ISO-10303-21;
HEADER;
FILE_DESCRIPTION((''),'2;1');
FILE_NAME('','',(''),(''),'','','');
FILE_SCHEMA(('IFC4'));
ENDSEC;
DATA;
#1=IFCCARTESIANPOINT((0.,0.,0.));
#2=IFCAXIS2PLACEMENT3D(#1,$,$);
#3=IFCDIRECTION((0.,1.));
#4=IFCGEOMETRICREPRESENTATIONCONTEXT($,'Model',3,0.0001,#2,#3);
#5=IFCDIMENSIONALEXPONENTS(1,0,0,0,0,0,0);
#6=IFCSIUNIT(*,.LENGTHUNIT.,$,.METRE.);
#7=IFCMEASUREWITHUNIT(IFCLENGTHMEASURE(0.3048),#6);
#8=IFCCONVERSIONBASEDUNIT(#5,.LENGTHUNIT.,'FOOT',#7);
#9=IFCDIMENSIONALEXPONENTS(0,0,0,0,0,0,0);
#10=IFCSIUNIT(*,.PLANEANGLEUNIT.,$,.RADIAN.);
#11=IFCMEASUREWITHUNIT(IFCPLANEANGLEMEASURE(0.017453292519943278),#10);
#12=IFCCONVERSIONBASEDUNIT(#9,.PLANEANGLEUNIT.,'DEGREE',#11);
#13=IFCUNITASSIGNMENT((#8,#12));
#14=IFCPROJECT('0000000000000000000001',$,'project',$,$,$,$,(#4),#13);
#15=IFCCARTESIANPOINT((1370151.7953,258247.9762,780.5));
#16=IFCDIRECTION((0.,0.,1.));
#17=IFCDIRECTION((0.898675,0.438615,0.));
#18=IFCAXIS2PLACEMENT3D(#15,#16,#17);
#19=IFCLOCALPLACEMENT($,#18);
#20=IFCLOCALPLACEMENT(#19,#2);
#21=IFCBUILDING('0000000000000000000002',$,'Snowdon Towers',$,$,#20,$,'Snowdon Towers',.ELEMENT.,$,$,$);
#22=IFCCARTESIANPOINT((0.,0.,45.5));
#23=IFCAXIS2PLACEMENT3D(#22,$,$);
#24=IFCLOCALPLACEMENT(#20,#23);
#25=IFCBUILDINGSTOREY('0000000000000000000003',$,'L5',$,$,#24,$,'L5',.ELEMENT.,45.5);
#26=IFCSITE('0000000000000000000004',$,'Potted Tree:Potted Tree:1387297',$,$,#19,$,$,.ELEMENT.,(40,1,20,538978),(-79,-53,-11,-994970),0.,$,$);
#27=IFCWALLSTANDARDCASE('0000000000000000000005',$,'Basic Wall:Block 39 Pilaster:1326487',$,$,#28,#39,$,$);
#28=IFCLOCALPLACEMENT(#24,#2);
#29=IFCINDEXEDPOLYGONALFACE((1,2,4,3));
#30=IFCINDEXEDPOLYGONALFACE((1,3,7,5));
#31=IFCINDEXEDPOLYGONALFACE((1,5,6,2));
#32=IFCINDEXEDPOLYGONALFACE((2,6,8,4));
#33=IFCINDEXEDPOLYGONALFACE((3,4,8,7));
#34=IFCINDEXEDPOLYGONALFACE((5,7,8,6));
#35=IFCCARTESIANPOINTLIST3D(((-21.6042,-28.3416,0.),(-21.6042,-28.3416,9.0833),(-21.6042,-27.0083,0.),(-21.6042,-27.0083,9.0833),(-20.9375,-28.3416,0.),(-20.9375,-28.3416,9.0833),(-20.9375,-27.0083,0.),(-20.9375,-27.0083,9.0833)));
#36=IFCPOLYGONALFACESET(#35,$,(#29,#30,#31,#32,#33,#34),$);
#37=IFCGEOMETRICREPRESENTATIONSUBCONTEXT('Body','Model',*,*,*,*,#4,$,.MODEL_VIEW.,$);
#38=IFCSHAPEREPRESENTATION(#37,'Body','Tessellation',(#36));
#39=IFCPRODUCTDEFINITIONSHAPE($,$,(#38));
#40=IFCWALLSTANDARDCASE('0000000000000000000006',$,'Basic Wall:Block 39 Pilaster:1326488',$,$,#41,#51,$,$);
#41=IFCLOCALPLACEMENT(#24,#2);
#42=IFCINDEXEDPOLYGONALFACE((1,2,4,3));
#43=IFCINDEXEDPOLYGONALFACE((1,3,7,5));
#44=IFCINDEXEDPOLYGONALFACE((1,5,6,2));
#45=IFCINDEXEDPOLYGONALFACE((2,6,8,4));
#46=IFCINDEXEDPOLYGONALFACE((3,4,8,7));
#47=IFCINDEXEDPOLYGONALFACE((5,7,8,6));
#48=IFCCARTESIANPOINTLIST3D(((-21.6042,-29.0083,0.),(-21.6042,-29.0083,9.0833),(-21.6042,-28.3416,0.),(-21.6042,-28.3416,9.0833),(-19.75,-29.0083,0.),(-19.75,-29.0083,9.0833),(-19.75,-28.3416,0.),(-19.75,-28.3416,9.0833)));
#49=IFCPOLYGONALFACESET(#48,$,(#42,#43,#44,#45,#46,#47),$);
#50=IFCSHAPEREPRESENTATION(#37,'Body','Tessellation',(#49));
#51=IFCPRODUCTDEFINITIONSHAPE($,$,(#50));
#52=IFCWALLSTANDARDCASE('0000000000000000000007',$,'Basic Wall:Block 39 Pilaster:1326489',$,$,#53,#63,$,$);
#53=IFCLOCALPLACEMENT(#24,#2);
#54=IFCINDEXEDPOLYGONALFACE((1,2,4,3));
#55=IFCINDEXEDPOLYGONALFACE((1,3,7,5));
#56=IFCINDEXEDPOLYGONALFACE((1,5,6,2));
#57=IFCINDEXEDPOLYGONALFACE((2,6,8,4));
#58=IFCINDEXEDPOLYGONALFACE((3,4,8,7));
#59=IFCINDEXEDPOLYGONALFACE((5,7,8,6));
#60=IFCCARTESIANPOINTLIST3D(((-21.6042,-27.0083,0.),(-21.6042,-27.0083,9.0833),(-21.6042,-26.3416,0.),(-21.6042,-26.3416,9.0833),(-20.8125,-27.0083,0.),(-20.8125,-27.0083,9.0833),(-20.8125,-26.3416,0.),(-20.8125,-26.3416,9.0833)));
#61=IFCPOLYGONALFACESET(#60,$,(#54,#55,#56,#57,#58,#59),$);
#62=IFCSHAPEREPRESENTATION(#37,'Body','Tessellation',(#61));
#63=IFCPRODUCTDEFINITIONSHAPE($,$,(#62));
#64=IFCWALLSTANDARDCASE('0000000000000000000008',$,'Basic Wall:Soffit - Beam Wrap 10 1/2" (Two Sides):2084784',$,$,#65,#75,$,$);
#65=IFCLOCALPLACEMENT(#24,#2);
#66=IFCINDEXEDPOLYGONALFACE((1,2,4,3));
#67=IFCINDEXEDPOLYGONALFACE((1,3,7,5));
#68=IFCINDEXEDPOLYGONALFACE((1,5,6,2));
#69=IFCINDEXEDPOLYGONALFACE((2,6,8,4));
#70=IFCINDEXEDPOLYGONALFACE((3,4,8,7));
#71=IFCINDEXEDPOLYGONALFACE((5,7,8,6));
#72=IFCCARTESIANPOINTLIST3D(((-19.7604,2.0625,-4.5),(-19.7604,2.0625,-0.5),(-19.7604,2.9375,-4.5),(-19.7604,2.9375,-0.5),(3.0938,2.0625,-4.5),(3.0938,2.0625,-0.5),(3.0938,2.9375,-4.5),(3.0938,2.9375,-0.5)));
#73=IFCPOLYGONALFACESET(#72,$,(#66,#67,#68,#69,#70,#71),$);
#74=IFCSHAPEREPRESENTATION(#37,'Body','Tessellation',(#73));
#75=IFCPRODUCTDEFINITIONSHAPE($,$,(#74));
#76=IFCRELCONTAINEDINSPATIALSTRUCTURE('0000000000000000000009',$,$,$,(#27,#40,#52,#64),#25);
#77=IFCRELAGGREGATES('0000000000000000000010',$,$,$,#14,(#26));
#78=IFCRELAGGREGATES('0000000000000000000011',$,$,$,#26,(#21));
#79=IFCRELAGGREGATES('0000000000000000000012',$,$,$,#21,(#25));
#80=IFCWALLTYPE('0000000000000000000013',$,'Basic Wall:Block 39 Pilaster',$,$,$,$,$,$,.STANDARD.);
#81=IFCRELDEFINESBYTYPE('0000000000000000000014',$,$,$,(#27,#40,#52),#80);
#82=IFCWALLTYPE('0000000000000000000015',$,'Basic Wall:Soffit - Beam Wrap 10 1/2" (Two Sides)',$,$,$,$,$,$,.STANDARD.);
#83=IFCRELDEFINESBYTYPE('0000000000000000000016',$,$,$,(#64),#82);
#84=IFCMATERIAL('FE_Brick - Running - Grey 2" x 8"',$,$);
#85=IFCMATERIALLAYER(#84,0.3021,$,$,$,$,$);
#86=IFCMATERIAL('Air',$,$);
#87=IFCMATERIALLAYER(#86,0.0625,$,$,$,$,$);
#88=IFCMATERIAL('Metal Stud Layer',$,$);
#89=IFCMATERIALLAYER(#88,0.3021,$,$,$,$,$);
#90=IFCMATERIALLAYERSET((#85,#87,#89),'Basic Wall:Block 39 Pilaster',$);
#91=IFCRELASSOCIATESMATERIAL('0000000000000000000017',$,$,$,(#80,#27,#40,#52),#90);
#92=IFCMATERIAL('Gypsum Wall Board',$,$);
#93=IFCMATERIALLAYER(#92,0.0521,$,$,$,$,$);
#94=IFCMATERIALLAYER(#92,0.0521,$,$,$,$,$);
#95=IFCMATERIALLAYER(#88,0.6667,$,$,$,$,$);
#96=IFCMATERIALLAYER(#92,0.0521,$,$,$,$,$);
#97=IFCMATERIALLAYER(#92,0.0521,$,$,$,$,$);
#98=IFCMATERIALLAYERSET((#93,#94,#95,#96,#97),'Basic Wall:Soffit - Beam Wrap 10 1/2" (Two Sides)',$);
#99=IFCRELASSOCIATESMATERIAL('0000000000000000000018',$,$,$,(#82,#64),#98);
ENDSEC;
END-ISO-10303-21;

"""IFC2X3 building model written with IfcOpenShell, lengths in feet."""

from ifc_helpers import new_model, entity, si_unit, converted_unit, direction, frame, frame_2d, origin, place, context, subcontext, project, spatial, rectangle, extrude, material, layer, layer_set, layer_usage, type_object, element, save


model = new_model("IFC2X3")

# Units and contexts
model_context = context("Model", 3, precision=0.0001, world=origin(), true_north=direction((0.0, 1.0)))
body_context = subcontext(model_context, "Body", "Model", "MODEL_VIEW")
ifc_project = project(units=[converted_unit("LENGTHUNIT", "FOOT", entity("IfcLengthMeasure", 0.3048), si_unit("LENGTHUNIT", "METRE"), dimensions=[1, 0, 0, 0, 0, 0, 0]), converted_unit("PLANEANGLEUNIT", "DEGREE", entity("IfcPlaneAngleMeasure", 0.017453292519943278), si_unit("PLANEANGLEUNIT", "RADIAN"), dimensions=[0, 0, 0, 0, 0, 0, 0])], contexts=[model_context])

# Site, building, storey
site_placement = place(None, frame((1370151.7953, 258247.9762, 780.5), z_axis=(0.0, 0.0, 1.0), x_axis=(0.898675, 0.438615, 0.0)))
site = spatial("IfcSite", under=ifc_project, at=site_placement, Name="Potted Tree:Potted Tree:1387297", CompositionType="ELEMENT", RefLatitude=(40, 1, 20, 538978), RefLongitude=(-79, -53, -11, -994970), RefElevation=0.0)
building_placement = place(site_placement, origin())
building = spatial("IfcBuilding", under=site, at=building_placement, Name="Snowdon Towers", LongName="Snowdon Towers", CompositionType="ELEMENT")
storey_placement = place(building_placement, frame((0.0, 0.0, 45.5)))
storey = spatial("IfcBuildingStorey", under=building, at=storey_placement, Name="L5", LongName="L5", CompositionType="ELEMENT", Elevation=45.5)

# Shared definitions
ifc_material_1 = material(Name="Gypsum Wall Board")

# Walls
ifc_material_2 = material(Name="Metal Stud Layer")
ifc_material_3 = material(Name="Air")
ifc_material_4 = material(Name="FE_Brick - Running - Grey 2\" x 8\"")
ifc_layer_1 = layer(ifc_material_4, 0.3021)
ifc_layer_2 = layer(ifc_material_3, 0.0625)
ifc_layer_3 = layer(ifc_material_2, 0.3021)
ifc_layer_set_1 = layer_set([ifc_layer_1, ifc_layer_2, ifc_layer_3], Name="Basic Wall:Block 39 Pilaster")
ifc_layer_usage_1 = layer_usage(ifc_layer_set_1, "AXIS2", "POSITIVE", -0.3333)
wall_type_1 = type_object("IfcWallType", Name="Basic Wall:Block 39 Pilaster", PredefinedType="STANDARD", material=ifc_layer_set_1)
wall_1_placement = place(storey_placement, frame((-21.2708, -27.0083, 0.0), z_axis=(0.0, 0.0, 1.0), x_axis=(0.0, -1.0, 0.0)))
element("IfcWallStandardCase", 1, at=wall_1_placement, inside=storey, type_object=wall_type_1, material=ifc_layer_usage_1, Name="Basic Wall:Block 39 Pilaster:1326487", context=body_context, shape_type="SweptSolid", body=[
    extrude(rectangle(XDim=1.3333, YDim=0.6667, at=frame_2d((0.6667, 0.0), x_axis=(-1.0, 0.0))), origin(), (0.0, 0.0, 1.0), 9.0833),
])
ifc_layer_usage_2 = layer_usage(ifc_layer_set_1, "AXIS2", "POSITIVE", -0.3333)
wall_2_placement = place(storey_placement, frame((-21.6042, -28.675, 0.0)))
element("IfcWallStandardCase", 2, at=wall_2_placement, inside=storey, type_object=wall_type_1, material=ifc_layer_usage_2, Name="Basic Wall:Block 39 Pilaster:1326488", context=body_context, shape_type="SweptSolid", body=[
    extrude(rectangle(XDim=1.8542, YDim=0.6667, at=frame_2d((0.9271, 0.0), x_axis=(-1.0, 0.0))), origin(), (0.0, 0.0, 1.0), 9.0833),
])
ifc_layer_usage_3 = layer_usage(ifc_layer_set_1, "AXIS2", "NEGATIVE", 0.3333)
wall_3_placement = place(storey_placement, frame((-21.6042, -26.675, 0.0)))
element("IfcWallStandardCase", 3, at=wall_3_placement, inside=storey, type_object=wall_type_1, material=ifc_layer_usage_3, Name="Basic Wall:Block 39 Pilaster:1326489", context=body_context, shape_type="SweptSolid", body=[
    extrude(rectangle(XDim=0.7917, YDim=0.6667, at=frame_2d((0.3958, 0.0), x_axis=(-1.0, 0.0))), origin(), (0.0, 0.0, 1.0), 9.0833),
])
ifc_layer_4 = layer(ifc_material_1, 0.0521)
ifc_layer_5 = layer(ifc_material_1, 0.0521)
ifc_layer_6 = layer(ifc_material_2, 0.6667)
ifc_layer_7 = layer(ifc_material_1, 0.0521)
ifc_layer_8 = layer(ifc_material_1, 0.0521)
ifc_layer_set_2 = layer_set([ifc_layer_4, ifc_layer_5, ifc_layer_6, ifc_layer_7, ifc_layer_8], Name="Basic Wall:Soffit - Beam Wrap 10 1/2\" (Two Sides)")
ifc_layer_usage_4 = layer_usage(ifc_layer_set_2, "AXIS2", "NEGATIVE", 0.4375)
wall_type_2 = type_object("IfcWallType", Name="Basic Wall:Soffit - Beam Wrap 10 1/2\" (Two Sides)", PredefinedType="STANDARD", material=ifc_layer_set_2)
wall_4_placement = place(storey_placement, frame((-19.7604, 2.5, -4.5)))
element("IfcWallStandardCase", 4, at=wall_4_placement, inside=storey, type_object=wall_type_2, material=ifc_layer_usage_4, Name="Basic Wall:Soffit - Beam Wrap 10 1/2\" (Two Sides):2084784", context=body_context, shape_type="SweptSolid", body=[
    extrude(rectangle(XDim=22.8542, YDim=0.875, at=frame_2d((11.4271, 0.0), x_axis=(-1.0, 0.0))), origin(), (0.0, 0.0, 1.0), 4.0),
])

save(model, "model.ifc")
